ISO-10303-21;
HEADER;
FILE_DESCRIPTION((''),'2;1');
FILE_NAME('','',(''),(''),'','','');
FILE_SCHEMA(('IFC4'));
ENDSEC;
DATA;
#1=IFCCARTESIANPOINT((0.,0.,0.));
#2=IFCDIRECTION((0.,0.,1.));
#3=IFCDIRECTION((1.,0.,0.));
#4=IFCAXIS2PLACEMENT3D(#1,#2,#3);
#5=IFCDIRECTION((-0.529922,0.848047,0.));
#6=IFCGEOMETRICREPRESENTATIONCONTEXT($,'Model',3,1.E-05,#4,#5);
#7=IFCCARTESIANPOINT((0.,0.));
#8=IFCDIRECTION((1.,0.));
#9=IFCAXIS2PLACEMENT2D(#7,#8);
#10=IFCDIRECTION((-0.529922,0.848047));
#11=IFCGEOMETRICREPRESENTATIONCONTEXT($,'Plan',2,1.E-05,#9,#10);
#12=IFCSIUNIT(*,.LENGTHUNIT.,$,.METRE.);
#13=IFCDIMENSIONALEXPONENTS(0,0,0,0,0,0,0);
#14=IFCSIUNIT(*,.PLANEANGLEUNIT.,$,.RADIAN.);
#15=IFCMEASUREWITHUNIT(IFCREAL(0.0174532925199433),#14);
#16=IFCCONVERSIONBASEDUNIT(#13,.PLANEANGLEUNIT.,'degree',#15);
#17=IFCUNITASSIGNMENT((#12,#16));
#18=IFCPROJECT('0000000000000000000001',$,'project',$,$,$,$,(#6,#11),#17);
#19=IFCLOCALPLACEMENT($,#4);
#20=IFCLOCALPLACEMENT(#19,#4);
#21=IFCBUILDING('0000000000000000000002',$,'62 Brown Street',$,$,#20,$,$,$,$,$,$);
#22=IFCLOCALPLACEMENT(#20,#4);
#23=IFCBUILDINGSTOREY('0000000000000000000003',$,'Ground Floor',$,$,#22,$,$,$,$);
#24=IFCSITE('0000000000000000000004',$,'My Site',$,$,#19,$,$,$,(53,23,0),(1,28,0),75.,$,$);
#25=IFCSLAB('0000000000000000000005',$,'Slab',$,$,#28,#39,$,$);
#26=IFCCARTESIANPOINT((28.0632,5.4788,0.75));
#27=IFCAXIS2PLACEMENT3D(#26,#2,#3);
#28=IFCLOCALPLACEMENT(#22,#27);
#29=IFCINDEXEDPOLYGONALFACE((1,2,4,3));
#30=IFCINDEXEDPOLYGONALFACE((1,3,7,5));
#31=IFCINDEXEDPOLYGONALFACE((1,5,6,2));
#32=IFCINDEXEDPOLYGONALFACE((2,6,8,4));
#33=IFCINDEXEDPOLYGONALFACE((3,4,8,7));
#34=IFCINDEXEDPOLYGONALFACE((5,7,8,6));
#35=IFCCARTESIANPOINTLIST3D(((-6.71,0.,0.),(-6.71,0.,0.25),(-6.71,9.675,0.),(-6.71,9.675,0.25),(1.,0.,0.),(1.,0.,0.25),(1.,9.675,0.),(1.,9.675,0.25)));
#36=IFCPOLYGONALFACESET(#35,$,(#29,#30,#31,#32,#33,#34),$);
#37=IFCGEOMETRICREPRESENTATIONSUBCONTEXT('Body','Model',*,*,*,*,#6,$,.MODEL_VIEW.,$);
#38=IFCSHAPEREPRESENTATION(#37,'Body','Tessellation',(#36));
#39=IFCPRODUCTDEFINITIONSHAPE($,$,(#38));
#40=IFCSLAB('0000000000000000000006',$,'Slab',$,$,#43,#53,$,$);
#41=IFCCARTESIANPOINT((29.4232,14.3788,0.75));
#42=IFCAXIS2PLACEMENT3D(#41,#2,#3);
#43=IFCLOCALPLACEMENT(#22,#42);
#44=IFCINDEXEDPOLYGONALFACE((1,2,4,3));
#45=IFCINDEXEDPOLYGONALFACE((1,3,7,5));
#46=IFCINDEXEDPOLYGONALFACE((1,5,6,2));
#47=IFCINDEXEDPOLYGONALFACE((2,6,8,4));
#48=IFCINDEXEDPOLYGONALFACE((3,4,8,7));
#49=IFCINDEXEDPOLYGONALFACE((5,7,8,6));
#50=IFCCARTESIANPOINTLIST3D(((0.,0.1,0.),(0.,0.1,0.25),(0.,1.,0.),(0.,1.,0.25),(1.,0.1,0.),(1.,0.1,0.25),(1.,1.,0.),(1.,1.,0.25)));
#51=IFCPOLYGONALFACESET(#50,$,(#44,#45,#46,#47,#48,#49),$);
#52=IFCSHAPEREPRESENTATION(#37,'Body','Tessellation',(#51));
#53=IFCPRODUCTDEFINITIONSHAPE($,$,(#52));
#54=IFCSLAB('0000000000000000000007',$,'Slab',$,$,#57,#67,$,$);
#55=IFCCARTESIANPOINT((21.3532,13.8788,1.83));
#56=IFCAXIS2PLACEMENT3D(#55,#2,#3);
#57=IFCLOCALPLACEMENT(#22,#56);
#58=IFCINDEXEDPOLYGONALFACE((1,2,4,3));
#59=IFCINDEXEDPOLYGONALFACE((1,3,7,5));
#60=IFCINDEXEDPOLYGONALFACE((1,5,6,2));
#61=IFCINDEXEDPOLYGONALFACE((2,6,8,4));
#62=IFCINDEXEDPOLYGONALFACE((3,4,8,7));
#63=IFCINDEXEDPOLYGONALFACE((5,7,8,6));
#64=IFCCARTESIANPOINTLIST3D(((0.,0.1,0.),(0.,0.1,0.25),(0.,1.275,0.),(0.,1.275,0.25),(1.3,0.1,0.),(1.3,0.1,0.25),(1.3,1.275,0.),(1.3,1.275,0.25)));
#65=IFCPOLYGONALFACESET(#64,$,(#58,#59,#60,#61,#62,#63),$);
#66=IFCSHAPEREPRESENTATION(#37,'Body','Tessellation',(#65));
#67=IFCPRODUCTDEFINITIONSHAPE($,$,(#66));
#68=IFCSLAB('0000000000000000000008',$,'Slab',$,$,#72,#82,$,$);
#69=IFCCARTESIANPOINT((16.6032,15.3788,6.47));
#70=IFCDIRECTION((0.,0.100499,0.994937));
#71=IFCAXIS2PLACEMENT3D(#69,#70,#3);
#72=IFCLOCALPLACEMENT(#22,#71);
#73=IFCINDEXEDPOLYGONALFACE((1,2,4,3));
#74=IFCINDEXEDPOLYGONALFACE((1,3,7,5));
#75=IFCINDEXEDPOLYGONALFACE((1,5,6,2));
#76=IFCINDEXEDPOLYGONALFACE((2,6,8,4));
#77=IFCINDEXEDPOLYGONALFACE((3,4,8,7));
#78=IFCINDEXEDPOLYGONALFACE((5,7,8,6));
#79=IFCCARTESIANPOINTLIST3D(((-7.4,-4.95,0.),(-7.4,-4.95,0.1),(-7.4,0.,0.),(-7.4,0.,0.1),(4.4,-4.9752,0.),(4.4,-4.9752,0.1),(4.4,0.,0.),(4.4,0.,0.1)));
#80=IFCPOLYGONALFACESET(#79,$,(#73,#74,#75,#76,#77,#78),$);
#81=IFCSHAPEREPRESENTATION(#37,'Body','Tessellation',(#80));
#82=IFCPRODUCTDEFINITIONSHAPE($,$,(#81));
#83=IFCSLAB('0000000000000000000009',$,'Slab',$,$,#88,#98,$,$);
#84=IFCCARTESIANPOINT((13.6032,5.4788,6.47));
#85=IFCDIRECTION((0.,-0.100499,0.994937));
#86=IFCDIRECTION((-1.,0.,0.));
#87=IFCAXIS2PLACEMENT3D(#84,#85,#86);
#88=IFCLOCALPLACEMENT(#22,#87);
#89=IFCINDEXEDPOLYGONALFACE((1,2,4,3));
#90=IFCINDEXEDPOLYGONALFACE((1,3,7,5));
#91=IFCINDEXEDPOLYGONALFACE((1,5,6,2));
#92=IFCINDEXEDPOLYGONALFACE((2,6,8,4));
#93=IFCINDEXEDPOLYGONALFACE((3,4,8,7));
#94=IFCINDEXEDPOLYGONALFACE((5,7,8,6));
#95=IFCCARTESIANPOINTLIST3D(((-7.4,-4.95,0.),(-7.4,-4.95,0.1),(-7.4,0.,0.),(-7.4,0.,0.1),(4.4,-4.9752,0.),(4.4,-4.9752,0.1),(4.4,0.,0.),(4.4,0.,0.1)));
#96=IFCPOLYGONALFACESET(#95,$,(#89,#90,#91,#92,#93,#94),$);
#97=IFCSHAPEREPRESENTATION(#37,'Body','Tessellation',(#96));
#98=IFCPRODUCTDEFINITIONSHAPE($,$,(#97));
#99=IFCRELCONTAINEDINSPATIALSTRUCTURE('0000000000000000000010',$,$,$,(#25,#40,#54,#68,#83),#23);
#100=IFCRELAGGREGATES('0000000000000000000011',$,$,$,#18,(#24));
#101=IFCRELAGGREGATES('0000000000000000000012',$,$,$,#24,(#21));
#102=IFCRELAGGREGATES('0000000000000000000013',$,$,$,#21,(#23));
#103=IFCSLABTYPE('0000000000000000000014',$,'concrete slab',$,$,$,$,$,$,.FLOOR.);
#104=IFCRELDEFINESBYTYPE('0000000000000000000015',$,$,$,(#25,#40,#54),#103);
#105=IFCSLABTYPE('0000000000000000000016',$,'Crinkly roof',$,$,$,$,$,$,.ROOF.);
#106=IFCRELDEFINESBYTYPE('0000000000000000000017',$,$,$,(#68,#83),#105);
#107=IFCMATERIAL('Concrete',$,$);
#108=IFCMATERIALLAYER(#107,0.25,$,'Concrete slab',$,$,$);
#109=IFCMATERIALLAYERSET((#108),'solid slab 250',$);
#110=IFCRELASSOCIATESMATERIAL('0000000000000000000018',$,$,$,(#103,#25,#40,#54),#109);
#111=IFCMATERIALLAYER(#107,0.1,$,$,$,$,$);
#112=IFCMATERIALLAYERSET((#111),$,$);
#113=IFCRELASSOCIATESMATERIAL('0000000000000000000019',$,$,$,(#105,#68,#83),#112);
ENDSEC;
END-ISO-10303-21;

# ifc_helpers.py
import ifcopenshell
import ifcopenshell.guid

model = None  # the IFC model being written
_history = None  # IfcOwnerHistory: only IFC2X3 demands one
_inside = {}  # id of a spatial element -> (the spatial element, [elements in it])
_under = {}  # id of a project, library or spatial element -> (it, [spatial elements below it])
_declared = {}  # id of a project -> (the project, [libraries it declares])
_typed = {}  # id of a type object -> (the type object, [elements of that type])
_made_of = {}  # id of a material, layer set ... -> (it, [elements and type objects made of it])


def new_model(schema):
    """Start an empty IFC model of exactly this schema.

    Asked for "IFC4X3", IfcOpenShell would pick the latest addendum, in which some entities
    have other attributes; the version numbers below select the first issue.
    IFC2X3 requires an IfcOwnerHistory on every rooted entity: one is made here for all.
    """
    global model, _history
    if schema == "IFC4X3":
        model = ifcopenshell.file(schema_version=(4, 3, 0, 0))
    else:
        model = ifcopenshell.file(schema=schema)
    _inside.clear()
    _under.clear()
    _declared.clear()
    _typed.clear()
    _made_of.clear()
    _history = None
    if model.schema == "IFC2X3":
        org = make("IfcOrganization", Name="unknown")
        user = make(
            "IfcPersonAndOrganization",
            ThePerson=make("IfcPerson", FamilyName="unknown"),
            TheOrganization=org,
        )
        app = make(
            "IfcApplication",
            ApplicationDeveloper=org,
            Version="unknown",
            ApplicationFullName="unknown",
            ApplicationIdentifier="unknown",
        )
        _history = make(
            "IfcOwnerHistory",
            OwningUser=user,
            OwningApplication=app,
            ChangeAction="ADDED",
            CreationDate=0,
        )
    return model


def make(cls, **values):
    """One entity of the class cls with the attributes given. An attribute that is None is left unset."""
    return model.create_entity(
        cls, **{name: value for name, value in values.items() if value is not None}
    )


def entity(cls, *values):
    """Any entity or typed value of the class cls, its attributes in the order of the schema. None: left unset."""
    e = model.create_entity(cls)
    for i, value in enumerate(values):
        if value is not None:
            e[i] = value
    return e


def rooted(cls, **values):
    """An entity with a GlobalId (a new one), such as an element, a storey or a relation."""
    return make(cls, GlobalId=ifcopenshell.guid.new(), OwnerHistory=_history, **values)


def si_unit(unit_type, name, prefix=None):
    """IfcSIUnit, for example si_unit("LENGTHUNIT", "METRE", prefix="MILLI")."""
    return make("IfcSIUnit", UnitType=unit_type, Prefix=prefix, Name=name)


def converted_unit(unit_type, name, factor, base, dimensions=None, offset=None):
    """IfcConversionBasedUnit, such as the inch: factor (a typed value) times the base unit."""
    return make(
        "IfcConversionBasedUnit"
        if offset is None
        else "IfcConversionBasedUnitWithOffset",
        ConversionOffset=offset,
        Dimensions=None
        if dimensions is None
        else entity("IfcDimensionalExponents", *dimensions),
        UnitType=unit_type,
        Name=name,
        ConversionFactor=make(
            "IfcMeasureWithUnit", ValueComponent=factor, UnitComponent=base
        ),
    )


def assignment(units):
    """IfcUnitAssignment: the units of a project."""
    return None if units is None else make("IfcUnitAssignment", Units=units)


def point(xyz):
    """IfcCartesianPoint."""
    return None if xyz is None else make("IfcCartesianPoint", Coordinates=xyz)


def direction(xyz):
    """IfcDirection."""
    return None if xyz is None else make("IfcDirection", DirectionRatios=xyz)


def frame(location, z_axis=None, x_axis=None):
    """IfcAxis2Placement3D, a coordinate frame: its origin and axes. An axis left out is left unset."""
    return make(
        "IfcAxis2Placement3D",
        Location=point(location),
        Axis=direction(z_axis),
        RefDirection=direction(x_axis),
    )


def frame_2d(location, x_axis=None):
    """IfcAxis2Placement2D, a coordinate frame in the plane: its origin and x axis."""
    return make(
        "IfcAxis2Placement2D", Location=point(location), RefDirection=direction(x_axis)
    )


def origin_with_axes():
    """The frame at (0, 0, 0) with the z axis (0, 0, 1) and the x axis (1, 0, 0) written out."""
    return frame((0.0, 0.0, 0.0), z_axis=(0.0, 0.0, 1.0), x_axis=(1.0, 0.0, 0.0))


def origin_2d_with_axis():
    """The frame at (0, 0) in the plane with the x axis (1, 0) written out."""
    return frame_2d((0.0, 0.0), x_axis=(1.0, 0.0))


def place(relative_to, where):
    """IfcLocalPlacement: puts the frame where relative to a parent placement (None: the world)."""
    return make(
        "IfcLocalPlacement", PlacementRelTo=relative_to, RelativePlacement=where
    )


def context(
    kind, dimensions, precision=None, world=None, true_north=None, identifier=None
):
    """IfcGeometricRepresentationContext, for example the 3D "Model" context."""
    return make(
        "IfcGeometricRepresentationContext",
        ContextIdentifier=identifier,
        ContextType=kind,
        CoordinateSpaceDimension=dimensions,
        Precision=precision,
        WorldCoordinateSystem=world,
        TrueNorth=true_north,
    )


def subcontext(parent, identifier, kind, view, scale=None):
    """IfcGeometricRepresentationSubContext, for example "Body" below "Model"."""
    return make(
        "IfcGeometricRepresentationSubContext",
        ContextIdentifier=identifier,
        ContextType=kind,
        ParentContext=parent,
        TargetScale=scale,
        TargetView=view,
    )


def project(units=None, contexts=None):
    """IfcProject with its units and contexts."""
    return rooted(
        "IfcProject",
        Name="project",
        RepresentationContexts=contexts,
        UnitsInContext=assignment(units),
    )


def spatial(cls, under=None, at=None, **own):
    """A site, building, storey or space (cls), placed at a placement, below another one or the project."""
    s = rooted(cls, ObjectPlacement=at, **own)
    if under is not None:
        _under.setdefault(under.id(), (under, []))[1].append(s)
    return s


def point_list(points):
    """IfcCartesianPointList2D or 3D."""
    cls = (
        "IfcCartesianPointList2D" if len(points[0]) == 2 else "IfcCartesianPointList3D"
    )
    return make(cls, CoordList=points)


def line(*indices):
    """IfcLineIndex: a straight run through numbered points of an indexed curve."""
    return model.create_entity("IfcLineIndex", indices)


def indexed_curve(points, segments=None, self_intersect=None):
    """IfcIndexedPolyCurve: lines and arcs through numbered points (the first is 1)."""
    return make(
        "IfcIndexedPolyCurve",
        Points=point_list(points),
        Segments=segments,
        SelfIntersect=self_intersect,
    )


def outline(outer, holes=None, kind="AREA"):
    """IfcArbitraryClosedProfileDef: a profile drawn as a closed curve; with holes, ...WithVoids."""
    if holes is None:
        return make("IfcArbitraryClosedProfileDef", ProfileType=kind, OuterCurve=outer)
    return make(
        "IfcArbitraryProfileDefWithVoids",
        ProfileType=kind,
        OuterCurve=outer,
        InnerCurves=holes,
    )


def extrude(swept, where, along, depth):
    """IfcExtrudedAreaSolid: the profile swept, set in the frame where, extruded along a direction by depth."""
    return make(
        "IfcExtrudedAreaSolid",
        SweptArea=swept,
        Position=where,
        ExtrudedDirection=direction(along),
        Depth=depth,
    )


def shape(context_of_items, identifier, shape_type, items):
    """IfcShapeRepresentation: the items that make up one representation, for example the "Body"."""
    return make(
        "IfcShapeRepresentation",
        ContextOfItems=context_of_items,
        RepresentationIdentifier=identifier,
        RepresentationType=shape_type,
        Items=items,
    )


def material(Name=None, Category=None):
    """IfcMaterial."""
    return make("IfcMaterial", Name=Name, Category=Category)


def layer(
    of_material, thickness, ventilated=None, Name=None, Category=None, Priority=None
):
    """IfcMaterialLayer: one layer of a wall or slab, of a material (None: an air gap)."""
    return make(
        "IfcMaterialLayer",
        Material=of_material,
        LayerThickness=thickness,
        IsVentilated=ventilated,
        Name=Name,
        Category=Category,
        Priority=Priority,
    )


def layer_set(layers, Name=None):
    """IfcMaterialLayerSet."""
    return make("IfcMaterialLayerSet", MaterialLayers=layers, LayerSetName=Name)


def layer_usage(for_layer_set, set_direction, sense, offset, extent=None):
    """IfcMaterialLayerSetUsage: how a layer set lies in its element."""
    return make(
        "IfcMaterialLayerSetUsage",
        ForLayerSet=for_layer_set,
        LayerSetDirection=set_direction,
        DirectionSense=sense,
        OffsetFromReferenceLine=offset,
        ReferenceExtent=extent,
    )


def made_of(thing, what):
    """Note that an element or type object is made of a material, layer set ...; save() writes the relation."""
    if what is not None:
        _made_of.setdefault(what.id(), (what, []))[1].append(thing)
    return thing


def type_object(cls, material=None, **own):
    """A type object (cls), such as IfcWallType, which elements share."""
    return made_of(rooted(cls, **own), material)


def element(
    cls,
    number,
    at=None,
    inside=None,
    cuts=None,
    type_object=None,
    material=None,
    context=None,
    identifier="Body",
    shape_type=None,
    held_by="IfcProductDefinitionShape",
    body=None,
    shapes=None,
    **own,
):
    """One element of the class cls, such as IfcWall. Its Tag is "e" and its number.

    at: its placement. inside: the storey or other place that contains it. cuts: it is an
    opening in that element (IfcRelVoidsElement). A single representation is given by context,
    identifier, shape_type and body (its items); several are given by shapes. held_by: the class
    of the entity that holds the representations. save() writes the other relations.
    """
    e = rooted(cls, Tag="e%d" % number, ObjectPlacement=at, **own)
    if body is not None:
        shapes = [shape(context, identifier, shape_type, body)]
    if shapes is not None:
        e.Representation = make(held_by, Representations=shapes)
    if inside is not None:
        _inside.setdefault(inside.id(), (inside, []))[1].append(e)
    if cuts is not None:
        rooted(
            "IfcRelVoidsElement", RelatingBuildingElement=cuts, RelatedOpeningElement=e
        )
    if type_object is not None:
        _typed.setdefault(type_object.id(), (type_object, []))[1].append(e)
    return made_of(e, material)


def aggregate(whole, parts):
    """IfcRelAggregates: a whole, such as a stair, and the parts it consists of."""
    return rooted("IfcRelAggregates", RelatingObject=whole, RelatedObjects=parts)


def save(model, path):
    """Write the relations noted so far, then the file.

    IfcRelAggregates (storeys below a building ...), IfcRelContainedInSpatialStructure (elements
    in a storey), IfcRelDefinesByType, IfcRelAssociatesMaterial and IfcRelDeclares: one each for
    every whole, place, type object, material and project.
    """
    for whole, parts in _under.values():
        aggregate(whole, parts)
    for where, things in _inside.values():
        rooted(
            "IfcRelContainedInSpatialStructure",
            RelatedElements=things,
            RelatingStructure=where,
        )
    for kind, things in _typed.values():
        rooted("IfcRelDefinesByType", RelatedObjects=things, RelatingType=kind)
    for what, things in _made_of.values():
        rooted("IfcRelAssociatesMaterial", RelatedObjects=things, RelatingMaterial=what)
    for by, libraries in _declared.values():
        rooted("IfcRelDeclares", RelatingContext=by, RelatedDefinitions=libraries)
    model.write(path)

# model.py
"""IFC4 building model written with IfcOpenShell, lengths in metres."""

from ifc_helpers import new_model, entity, si_unit, converted_unit, direction, frame, origin_with_axes, origin_2d_with_axis, place, context, subcontext, project, spatial, line, indexed_curve, outline, extrude, material, layer, layer_set, layer_usage, type_object, element, save


model = new_model("IFC4")

# Units and contexts
model_context = context("Model", 3, precision=1e-05, world=origin_with_axes(), true_north=direction((-0.529922, 0.848047, 0.0)))
plan_context = context("Plan", 2, precision=1e-05, world=origin_2d_with_axis(), true_north=direction((-0.529922, 0.848047)))
body_context_1 = subcontext(model_context, "Body", "Model", "MODEL_VIEW")
ifc_project = project(units=[si_unit("LENGTHUNIT", "METRE"), converted_unit("PLANEANGLEUNIT", "degree", entity("IfcReal", 0.0174532925199433), si_unit("PLANEANGLEUNIT", "RADIAN"), dimensions=[0, 0, 0, 0, 0, 0, 0])], contexts=[model_context, plan_context])

# Site, building, storey
site_placement = place(None, origin_with_axes())
site = spatial("IfcSite", under=ifc_project, at=site_placement, Name="My Site", RefLatitude=(53, 23, 0), RefLongitude=(1, 28, 0), RefElevation=75.0)
building_placement = place(site_placement, origin_with_axes())
building = spatial("IfcBuilding", under=site, at=building_placement, Name="62 Brown Street")
storey_placement = place(building_placement, origin_with_axes())
storey = spatial("IfcBuildingStorey", under=building, at=storey_placement, Name="Ground Floor")

# Shared definitions
ifc_material_1 = material(Name="Concrete")

# Slabs
ifc_layer_1 = layer(ifc_material_1, 0.25, Name="Concrete slab")
ifc_layer_set_1 = layer_set([ifc_layer_1], Name="solid slab 250")
slab_type_1 = type_object("IfcSlabType", Name="concrete slab", PredefinedType="FLOOR", material=ifc_layer_set_1)
ifc_layer_usage_1 = layer_usage(ifc_layer_set_1, "AXIS3", "POSITIVE", 0.0)
slab_1_placement = place(storey_placement, frame((28.0632, 5.4788, 0.75), z_axis=(0.0, 0.0, 1.0), x_axis=(1.0, 0.0, 0.0)))
element("IfcSlab", 1, at=slab_1_placement, inside=storey, type_object=slab_type_1, material=ifc_layer_usage_1, Name="Slab", context=body_context_1, shape_type="SweptSolid", body=[
    extrude(outline(indexed_curve([(-6.71, 0.0), (-6.71, 9.675), (1.0, 9.675), (1.0, 0.0), (-6.71, 0.0)])), None, (0.0, 0.0, 1.0), 0.25),
])
ifc_layer_usage_2 = layer_usage(ifc_layer_set_1, "AXIS3", "POSITIVE", 0.0)
slab_2_placement = place(storey_placement, frame((29.4232, 14.3788, 0.75), z_axis=(0.0, 0.0, 1.0), x_axis=(1.0, 0.0, 0.0)))
element("IfcSlab", 2, at=slab_2_placement, inside=storey, type_object=slab_type_1, material=ifc_layer_usage_2, Name="Slab", context=body_context_1, shape_type="SweptSolid", body=[
    extrude(outline(indexed_curve([(1.0, 1.0), (1.0, 0.1), (0.0, 0.1), (0.0, 1.0)], segments=[line(3, 2), line(2, 1), line(1, 4), line(4, 3)], self_intersect=False)), None, (0.0, 0.0, 1.0), 0.25),
])
ifc_layer_usage_3 = layer_usage(ifc_layer_set_1, "AXIS3", "POSITIVE", 0.0)
slab_3_placement = place(storey_placement, frame((21.3532, 13.8788, 1.83), z_axis=(0.0, 0.0, 1.0), x_axis=(1.0, 0.0, 0.0)))
element("IfcSlab", 3, at=slab_3_placement, inside=storey, type_object=slab_type_1, material=ifc_layer_usage_3, Name="Slab", context=body_context_1, shape_type="SweptSolid", body=[
    extrude(outline(indexed_curve([(0.0, 0.1), (1.3, 0.1), (1.3, 1.275), (0.0, 1.275), (0.0, 0.1)])), None, (0.0, 0.0, 1.0), 0.25),
])
ifc_layer_2 = layer(ifc_material_1, 0.1)
ifc_layer_set_2 = layer_set([ifc_layer_2])
ifc_layer_usage_4 = layer_usage(ifc_layer_set_2, "AXIS3", "POSITIVE", 0.0)
slab_type_2 = type_object("IfcSlabType", Name="Crinkly roof", PredefinedType="ROOF", material=ifc_layer_set_2)
slab_4_placement = place(storey_placement, frame((16.6032, 15.3788, 6.47), z_axis=(0.0, 0.100499, 0.994937), x_axis=(1.0, 0.0, 0.0)))
element("IfcSlab", 4, at=slab_4_placement, inside=storey, type_object=slab_type_2, material=ifc_layer_usage_4, Name="Slab", context=body_context_1, shape_type="SweptSolid", body=[
    extrude(outline(indexed_curve([(4.4, 0.0), (-7.4, 0.0), (-7.4, -4.95), (4.4, -4.9752), (4.4, 0.0)])), None, (0.0, 0.0, 1.0), 0.1),
])
ifc_layer_usage_5 = layer_usage(ifc_layer_set_2, "AXIS3", "POSITIVE", 0.0)
slab_5_placement = place(storey_placement, frame((13.6032, 5.4788, 6.47), z_axis=(0.0, -0.100499, 0.994937), x_axis=(-1.0, 0.0, 0.0)))
element("IfcSlab", 5, at=slab_5_placement, inside=storey, type_object=slab_type_2, material=ifc_layer_usage_5, Name="Slab", context=body_context_1, shape_type="SweptSolid", body=[
    extrude(outline(indexed_curve([(4.4, 0.0), (-7.4, 0.0), (-7.4, -4.95), (4.4, -4.9752), (4.4, 0.0)])), None, (0.0, 0.0, 1.0), 0.1),
])

save(model, "model.ifc")
